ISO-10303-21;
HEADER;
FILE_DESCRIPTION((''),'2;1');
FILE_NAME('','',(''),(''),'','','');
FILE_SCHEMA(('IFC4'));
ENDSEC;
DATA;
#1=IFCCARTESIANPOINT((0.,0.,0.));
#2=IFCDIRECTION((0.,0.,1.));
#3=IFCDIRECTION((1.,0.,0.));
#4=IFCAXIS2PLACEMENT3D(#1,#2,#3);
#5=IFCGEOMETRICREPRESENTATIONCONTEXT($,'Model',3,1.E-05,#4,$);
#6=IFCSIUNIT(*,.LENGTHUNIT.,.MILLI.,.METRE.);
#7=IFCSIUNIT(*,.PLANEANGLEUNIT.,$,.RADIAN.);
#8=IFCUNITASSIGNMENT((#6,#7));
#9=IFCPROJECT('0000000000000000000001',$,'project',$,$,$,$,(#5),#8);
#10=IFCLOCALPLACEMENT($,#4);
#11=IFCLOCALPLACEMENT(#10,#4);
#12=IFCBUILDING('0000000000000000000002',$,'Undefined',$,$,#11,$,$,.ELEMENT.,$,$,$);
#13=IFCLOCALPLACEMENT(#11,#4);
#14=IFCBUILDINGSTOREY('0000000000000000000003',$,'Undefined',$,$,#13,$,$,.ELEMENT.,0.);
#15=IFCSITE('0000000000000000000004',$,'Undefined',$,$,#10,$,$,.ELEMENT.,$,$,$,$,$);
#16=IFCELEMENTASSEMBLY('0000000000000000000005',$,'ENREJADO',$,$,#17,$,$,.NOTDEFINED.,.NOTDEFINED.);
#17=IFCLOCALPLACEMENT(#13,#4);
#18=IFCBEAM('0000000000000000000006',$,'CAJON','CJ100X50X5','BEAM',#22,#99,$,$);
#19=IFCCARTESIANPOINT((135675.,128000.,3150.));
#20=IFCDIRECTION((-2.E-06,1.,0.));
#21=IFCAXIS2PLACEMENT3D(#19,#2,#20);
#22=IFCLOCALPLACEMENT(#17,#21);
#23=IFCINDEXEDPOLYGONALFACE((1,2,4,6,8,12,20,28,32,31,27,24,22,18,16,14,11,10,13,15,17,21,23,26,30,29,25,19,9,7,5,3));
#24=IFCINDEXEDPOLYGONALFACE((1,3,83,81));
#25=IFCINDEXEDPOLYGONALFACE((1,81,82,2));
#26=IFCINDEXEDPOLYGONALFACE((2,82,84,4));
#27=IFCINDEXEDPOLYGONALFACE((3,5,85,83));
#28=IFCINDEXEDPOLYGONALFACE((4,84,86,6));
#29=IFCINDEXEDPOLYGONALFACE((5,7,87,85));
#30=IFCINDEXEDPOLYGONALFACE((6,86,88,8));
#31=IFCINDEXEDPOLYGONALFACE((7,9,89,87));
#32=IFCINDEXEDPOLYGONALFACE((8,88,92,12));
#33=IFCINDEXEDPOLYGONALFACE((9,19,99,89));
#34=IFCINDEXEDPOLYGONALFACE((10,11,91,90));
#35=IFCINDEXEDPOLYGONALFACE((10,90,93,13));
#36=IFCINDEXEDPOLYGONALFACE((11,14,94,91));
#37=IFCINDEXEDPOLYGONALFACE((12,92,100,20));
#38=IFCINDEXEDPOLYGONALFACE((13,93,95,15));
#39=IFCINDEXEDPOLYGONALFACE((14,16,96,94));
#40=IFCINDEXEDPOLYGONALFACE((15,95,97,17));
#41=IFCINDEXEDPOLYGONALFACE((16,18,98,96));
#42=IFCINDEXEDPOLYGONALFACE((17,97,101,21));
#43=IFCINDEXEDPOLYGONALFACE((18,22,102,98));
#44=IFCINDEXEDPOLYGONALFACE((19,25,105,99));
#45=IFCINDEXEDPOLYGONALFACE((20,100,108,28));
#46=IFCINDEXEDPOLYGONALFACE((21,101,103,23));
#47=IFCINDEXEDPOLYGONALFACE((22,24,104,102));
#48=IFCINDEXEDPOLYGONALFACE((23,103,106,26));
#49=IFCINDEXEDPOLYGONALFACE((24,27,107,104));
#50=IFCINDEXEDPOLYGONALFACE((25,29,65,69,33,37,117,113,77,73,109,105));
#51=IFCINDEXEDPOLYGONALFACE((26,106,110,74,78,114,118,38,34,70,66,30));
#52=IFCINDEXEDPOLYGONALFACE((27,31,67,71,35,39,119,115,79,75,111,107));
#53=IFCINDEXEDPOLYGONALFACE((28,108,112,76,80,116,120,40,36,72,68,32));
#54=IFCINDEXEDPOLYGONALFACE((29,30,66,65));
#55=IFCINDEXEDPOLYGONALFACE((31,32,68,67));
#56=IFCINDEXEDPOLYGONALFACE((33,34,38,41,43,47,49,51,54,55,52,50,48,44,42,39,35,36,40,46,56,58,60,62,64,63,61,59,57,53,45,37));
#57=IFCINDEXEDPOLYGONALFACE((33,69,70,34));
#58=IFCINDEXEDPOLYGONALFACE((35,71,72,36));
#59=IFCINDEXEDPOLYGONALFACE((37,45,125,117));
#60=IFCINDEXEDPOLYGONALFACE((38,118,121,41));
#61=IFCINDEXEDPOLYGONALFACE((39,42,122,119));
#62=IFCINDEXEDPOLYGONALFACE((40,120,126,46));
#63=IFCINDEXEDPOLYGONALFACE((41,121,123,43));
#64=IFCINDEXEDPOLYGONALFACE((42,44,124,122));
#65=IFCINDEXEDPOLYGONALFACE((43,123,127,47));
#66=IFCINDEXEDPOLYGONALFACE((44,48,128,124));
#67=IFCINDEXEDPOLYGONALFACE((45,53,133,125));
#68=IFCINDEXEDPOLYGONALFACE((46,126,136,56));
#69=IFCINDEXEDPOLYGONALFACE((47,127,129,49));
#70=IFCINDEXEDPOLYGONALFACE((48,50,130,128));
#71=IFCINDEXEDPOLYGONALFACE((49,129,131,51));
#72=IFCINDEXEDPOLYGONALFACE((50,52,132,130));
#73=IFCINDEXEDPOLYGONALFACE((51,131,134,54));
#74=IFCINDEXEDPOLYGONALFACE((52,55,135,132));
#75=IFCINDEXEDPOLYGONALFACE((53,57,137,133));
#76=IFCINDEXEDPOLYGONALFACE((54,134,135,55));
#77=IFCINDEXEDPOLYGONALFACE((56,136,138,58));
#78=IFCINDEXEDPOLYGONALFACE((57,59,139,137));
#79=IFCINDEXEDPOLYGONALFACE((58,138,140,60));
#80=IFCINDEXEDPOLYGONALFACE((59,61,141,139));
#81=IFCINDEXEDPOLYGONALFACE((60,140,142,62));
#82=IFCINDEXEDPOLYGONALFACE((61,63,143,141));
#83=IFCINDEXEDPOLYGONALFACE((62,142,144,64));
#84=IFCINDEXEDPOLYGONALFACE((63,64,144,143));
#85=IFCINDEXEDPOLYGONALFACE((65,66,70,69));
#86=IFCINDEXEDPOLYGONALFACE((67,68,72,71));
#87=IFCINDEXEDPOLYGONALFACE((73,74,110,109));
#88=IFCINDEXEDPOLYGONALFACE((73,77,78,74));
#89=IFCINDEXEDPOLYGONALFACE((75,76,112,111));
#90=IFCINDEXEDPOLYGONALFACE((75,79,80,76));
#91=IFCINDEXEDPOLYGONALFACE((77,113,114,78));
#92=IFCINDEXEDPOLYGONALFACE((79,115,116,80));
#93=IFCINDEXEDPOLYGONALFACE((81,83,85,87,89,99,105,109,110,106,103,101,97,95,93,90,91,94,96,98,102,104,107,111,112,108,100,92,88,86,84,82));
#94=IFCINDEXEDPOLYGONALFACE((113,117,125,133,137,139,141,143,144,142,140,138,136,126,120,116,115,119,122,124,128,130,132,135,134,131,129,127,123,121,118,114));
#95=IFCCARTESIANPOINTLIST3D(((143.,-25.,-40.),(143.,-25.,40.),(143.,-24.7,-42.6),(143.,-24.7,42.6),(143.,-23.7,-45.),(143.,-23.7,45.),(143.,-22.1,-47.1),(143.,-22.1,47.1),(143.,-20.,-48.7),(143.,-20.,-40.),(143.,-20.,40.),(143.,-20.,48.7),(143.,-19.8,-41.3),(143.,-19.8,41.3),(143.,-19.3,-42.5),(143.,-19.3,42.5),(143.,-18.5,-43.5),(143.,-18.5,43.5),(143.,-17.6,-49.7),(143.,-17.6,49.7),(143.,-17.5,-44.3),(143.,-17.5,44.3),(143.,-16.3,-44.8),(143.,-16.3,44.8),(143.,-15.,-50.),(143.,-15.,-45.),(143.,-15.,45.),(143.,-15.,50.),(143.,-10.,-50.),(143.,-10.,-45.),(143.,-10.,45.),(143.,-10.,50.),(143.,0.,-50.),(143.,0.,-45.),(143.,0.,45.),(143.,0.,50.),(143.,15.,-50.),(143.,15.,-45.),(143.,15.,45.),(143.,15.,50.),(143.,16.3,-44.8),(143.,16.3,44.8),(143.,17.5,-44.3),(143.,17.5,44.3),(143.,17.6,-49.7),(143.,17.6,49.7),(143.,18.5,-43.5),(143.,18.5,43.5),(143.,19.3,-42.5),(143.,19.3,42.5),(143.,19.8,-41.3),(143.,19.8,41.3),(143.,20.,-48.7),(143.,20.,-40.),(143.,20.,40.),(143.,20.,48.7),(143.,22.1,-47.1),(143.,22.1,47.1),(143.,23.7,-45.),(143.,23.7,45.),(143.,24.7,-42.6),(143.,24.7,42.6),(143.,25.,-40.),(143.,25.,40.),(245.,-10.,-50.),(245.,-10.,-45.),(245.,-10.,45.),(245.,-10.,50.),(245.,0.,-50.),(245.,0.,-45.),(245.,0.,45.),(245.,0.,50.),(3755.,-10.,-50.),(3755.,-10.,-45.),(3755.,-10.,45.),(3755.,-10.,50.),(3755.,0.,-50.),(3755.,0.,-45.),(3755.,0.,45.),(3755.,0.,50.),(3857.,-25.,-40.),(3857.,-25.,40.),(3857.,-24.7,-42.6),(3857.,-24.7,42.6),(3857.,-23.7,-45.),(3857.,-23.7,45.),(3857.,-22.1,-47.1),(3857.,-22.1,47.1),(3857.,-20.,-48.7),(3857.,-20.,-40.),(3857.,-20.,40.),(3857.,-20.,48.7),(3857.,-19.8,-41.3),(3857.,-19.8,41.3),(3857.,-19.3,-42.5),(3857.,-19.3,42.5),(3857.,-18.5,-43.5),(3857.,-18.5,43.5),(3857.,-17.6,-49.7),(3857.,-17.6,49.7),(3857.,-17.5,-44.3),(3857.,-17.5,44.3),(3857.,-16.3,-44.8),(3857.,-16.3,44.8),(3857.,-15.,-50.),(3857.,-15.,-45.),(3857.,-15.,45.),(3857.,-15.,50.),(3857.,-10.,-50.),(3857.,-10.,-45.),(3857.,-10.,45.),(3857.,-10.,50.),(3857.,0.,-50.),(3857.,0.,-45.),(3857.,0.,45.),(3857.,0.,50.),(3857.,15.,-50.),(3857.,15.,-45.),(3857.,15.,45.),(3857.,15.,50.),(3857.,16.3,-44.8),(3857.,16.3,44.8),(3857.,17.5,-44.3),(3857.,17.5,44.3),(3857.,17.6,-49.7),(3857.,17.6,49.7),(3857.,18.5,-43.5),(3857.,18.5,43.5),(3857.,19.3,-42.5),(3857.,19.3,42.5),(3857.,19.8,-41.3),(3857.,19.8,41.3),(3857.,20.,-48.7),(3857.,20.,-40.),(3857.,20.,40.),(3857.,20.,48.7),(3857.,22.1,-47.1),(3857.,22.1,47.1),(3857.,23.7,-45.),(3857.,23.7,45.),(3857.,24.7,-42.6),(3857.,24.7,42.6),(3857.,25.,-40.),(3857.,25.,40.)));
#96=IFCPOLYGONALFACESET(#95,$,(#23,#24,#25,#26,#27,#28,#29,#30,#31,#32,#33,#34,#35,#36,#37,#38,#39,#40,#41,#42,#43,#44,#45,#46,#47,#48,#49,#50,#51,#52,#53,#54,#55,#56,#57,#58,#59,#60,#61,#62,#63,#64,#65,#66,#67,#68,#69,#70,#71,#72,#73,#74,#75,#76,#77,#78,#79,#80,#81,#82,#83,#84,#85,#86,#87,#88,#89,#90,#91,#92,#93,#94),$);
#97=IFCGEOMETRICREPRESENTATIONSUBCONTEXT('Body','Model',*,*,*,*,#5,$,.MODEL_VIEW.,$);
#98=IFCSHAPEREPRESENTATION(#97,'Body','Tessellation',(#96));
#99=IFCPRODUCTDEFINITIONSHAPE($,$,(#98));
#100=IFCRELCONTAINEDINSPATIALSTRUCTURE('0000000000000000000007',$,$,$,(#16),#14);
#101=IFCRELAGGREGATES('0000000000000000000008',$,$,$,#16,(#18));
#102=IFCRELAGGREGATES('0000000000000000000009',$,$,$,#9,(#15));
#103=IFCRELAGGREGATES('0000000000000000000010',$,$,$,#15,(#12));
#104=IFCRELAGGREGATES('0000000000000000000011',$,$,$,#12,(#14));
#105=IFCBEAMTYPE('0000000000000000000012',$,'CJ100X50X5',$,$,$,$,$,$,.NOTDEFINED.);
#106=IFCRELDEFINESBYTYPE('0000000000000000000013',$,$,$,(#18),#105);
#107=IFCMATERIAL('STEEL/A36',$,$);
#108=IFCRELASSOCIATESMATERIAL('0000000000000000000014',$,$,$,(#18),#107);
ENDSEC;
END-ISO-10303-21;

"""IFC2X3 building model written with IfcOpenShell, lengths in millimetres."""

from ifc_helpers import new_model, si_unit, frame, origin_with_axes, origin_2d_with_axis, place, context, subcontext, project, spatial, rectangle, hollow_rectangle, extrude, boolean, halfspace, material, type_object, element, aggregate, save


model = new_model("IFC2X3")

# Units and contexts
model_context = context("Model", 3, precision=1e-05, world=origin_with_axes())
body_context = subcontext(model_context, "Body", "Model", "MODEL_VIEW")
ifc_project = project(units=[si_unit("LENGTHUNIT", "METRE", prefix="MILLI"), si_unit("PLANEANGLEUNIT", "RADIAN")], contexts=[model_context])

# Site, building, storey
site_placement = place(None, origin_with_axes())
site = spatial("IfcSite", under=ifc_project, at=site_placement, Name="Undefined", CompositionType="ELEMENT")
building_placement = place(site_placement, origin_with_axes())
building = spatial("IfcBuilding", under=site, at=building_placement, Name="Undefined", CompositionType="ELEMENT")
storey_placement = place(building_placement, origin_with_axes())
storey = spatial("IfcBuildingStorey", under=building, at=storey_placement, Name="Undefined", CompositionType="ELEMENT", Elevation=0.0)

# Shared definitions
ifc_material_1 = material(Name="STEEL/A36")

# Shared definitions
beam_type_1 = type_object("IfcBeamType", Name="CJ100X50X5", PredefinedType="NOTDEFINED")

# Element assembly, beam
assembly_1_placement = place(storey_placement, origin_with_axes())
assembly_1 = element("IfcElementAssembly", 1, at=assembly_1_placement, inside=storey, Name="ENREJADO", AssemblyPlace="NOTDEFINED", PredefinedType="NOTDEFINED")
beam_1_placement = place(assembly_1_placement, frame((135675.0, 128000.0, 3150.0), z_axis=(0.0, 0.0, 1.0), x_axis=(-0.000002, 1.0, 0.0)))
beam_1 = element("IfcBeam", 2, at=beam_1_placement, type_object=beam_type_1, material=ifc_material_1, Name="CAJON", Description="CJ100X50X5", ObjectType="BEAM", context=body_context, shape_type="CSG", body=[
    boolean("DIFFERENCE", boolean("DIFFERENCE", boolean("DIFFERENCE", boolean("DIFFERENCE", extrude(hollow_rectangle(XDim=50.0, YDim=100.0, WallThickness=5.0, InnerFilletRadius=5.0, OuterFilletRadius=10.0, at=origin_2d_with_axis()), frame((4000.0, 0.0, 0.0), z_axis=(-1.0, 0.0, 0.0), x_axis=(0.0, -1.0, 0.0)), (0.0, 0.0, 1.0), 4000.0), extrude(rectangle(XDim=10.0, YDim=104.0, at=origin_2d_with_axis()), frame((3755.0, -5.0, 0.0), z_axis=(1.0, 0.0, 0.0), x_axis=(0.0, 1.0, 0.0)), (0.0, 0.0, 1.0), 120.0)), extrude(rectangle(XDim=10.0, YDim=104.0, at=origin_2d_with_axis()), frame((245.0, -5.0, 0.0), z_axis=(-1.0, 0.000003, 0.0), x_axis=(0.000002, 1.0, 0.0)), (0.0, 0.0, 1.0), 120.0)), halfspace(frame((3857.0, 200.0, 50.0), z_axis=(-1.0, 0.0, 0.0), x_axis=(0.0, -1.0, 0.0)), True)), halfspace(frame((143.0, 200.0, -50.0), z_axis=(1.0, -0.000003, 0.0), x_axis=(-0.000002, -1.0, 0.0)), True)),
])

aggregate(assembly_1, [beam_1])

save(model, "model.ifc")
